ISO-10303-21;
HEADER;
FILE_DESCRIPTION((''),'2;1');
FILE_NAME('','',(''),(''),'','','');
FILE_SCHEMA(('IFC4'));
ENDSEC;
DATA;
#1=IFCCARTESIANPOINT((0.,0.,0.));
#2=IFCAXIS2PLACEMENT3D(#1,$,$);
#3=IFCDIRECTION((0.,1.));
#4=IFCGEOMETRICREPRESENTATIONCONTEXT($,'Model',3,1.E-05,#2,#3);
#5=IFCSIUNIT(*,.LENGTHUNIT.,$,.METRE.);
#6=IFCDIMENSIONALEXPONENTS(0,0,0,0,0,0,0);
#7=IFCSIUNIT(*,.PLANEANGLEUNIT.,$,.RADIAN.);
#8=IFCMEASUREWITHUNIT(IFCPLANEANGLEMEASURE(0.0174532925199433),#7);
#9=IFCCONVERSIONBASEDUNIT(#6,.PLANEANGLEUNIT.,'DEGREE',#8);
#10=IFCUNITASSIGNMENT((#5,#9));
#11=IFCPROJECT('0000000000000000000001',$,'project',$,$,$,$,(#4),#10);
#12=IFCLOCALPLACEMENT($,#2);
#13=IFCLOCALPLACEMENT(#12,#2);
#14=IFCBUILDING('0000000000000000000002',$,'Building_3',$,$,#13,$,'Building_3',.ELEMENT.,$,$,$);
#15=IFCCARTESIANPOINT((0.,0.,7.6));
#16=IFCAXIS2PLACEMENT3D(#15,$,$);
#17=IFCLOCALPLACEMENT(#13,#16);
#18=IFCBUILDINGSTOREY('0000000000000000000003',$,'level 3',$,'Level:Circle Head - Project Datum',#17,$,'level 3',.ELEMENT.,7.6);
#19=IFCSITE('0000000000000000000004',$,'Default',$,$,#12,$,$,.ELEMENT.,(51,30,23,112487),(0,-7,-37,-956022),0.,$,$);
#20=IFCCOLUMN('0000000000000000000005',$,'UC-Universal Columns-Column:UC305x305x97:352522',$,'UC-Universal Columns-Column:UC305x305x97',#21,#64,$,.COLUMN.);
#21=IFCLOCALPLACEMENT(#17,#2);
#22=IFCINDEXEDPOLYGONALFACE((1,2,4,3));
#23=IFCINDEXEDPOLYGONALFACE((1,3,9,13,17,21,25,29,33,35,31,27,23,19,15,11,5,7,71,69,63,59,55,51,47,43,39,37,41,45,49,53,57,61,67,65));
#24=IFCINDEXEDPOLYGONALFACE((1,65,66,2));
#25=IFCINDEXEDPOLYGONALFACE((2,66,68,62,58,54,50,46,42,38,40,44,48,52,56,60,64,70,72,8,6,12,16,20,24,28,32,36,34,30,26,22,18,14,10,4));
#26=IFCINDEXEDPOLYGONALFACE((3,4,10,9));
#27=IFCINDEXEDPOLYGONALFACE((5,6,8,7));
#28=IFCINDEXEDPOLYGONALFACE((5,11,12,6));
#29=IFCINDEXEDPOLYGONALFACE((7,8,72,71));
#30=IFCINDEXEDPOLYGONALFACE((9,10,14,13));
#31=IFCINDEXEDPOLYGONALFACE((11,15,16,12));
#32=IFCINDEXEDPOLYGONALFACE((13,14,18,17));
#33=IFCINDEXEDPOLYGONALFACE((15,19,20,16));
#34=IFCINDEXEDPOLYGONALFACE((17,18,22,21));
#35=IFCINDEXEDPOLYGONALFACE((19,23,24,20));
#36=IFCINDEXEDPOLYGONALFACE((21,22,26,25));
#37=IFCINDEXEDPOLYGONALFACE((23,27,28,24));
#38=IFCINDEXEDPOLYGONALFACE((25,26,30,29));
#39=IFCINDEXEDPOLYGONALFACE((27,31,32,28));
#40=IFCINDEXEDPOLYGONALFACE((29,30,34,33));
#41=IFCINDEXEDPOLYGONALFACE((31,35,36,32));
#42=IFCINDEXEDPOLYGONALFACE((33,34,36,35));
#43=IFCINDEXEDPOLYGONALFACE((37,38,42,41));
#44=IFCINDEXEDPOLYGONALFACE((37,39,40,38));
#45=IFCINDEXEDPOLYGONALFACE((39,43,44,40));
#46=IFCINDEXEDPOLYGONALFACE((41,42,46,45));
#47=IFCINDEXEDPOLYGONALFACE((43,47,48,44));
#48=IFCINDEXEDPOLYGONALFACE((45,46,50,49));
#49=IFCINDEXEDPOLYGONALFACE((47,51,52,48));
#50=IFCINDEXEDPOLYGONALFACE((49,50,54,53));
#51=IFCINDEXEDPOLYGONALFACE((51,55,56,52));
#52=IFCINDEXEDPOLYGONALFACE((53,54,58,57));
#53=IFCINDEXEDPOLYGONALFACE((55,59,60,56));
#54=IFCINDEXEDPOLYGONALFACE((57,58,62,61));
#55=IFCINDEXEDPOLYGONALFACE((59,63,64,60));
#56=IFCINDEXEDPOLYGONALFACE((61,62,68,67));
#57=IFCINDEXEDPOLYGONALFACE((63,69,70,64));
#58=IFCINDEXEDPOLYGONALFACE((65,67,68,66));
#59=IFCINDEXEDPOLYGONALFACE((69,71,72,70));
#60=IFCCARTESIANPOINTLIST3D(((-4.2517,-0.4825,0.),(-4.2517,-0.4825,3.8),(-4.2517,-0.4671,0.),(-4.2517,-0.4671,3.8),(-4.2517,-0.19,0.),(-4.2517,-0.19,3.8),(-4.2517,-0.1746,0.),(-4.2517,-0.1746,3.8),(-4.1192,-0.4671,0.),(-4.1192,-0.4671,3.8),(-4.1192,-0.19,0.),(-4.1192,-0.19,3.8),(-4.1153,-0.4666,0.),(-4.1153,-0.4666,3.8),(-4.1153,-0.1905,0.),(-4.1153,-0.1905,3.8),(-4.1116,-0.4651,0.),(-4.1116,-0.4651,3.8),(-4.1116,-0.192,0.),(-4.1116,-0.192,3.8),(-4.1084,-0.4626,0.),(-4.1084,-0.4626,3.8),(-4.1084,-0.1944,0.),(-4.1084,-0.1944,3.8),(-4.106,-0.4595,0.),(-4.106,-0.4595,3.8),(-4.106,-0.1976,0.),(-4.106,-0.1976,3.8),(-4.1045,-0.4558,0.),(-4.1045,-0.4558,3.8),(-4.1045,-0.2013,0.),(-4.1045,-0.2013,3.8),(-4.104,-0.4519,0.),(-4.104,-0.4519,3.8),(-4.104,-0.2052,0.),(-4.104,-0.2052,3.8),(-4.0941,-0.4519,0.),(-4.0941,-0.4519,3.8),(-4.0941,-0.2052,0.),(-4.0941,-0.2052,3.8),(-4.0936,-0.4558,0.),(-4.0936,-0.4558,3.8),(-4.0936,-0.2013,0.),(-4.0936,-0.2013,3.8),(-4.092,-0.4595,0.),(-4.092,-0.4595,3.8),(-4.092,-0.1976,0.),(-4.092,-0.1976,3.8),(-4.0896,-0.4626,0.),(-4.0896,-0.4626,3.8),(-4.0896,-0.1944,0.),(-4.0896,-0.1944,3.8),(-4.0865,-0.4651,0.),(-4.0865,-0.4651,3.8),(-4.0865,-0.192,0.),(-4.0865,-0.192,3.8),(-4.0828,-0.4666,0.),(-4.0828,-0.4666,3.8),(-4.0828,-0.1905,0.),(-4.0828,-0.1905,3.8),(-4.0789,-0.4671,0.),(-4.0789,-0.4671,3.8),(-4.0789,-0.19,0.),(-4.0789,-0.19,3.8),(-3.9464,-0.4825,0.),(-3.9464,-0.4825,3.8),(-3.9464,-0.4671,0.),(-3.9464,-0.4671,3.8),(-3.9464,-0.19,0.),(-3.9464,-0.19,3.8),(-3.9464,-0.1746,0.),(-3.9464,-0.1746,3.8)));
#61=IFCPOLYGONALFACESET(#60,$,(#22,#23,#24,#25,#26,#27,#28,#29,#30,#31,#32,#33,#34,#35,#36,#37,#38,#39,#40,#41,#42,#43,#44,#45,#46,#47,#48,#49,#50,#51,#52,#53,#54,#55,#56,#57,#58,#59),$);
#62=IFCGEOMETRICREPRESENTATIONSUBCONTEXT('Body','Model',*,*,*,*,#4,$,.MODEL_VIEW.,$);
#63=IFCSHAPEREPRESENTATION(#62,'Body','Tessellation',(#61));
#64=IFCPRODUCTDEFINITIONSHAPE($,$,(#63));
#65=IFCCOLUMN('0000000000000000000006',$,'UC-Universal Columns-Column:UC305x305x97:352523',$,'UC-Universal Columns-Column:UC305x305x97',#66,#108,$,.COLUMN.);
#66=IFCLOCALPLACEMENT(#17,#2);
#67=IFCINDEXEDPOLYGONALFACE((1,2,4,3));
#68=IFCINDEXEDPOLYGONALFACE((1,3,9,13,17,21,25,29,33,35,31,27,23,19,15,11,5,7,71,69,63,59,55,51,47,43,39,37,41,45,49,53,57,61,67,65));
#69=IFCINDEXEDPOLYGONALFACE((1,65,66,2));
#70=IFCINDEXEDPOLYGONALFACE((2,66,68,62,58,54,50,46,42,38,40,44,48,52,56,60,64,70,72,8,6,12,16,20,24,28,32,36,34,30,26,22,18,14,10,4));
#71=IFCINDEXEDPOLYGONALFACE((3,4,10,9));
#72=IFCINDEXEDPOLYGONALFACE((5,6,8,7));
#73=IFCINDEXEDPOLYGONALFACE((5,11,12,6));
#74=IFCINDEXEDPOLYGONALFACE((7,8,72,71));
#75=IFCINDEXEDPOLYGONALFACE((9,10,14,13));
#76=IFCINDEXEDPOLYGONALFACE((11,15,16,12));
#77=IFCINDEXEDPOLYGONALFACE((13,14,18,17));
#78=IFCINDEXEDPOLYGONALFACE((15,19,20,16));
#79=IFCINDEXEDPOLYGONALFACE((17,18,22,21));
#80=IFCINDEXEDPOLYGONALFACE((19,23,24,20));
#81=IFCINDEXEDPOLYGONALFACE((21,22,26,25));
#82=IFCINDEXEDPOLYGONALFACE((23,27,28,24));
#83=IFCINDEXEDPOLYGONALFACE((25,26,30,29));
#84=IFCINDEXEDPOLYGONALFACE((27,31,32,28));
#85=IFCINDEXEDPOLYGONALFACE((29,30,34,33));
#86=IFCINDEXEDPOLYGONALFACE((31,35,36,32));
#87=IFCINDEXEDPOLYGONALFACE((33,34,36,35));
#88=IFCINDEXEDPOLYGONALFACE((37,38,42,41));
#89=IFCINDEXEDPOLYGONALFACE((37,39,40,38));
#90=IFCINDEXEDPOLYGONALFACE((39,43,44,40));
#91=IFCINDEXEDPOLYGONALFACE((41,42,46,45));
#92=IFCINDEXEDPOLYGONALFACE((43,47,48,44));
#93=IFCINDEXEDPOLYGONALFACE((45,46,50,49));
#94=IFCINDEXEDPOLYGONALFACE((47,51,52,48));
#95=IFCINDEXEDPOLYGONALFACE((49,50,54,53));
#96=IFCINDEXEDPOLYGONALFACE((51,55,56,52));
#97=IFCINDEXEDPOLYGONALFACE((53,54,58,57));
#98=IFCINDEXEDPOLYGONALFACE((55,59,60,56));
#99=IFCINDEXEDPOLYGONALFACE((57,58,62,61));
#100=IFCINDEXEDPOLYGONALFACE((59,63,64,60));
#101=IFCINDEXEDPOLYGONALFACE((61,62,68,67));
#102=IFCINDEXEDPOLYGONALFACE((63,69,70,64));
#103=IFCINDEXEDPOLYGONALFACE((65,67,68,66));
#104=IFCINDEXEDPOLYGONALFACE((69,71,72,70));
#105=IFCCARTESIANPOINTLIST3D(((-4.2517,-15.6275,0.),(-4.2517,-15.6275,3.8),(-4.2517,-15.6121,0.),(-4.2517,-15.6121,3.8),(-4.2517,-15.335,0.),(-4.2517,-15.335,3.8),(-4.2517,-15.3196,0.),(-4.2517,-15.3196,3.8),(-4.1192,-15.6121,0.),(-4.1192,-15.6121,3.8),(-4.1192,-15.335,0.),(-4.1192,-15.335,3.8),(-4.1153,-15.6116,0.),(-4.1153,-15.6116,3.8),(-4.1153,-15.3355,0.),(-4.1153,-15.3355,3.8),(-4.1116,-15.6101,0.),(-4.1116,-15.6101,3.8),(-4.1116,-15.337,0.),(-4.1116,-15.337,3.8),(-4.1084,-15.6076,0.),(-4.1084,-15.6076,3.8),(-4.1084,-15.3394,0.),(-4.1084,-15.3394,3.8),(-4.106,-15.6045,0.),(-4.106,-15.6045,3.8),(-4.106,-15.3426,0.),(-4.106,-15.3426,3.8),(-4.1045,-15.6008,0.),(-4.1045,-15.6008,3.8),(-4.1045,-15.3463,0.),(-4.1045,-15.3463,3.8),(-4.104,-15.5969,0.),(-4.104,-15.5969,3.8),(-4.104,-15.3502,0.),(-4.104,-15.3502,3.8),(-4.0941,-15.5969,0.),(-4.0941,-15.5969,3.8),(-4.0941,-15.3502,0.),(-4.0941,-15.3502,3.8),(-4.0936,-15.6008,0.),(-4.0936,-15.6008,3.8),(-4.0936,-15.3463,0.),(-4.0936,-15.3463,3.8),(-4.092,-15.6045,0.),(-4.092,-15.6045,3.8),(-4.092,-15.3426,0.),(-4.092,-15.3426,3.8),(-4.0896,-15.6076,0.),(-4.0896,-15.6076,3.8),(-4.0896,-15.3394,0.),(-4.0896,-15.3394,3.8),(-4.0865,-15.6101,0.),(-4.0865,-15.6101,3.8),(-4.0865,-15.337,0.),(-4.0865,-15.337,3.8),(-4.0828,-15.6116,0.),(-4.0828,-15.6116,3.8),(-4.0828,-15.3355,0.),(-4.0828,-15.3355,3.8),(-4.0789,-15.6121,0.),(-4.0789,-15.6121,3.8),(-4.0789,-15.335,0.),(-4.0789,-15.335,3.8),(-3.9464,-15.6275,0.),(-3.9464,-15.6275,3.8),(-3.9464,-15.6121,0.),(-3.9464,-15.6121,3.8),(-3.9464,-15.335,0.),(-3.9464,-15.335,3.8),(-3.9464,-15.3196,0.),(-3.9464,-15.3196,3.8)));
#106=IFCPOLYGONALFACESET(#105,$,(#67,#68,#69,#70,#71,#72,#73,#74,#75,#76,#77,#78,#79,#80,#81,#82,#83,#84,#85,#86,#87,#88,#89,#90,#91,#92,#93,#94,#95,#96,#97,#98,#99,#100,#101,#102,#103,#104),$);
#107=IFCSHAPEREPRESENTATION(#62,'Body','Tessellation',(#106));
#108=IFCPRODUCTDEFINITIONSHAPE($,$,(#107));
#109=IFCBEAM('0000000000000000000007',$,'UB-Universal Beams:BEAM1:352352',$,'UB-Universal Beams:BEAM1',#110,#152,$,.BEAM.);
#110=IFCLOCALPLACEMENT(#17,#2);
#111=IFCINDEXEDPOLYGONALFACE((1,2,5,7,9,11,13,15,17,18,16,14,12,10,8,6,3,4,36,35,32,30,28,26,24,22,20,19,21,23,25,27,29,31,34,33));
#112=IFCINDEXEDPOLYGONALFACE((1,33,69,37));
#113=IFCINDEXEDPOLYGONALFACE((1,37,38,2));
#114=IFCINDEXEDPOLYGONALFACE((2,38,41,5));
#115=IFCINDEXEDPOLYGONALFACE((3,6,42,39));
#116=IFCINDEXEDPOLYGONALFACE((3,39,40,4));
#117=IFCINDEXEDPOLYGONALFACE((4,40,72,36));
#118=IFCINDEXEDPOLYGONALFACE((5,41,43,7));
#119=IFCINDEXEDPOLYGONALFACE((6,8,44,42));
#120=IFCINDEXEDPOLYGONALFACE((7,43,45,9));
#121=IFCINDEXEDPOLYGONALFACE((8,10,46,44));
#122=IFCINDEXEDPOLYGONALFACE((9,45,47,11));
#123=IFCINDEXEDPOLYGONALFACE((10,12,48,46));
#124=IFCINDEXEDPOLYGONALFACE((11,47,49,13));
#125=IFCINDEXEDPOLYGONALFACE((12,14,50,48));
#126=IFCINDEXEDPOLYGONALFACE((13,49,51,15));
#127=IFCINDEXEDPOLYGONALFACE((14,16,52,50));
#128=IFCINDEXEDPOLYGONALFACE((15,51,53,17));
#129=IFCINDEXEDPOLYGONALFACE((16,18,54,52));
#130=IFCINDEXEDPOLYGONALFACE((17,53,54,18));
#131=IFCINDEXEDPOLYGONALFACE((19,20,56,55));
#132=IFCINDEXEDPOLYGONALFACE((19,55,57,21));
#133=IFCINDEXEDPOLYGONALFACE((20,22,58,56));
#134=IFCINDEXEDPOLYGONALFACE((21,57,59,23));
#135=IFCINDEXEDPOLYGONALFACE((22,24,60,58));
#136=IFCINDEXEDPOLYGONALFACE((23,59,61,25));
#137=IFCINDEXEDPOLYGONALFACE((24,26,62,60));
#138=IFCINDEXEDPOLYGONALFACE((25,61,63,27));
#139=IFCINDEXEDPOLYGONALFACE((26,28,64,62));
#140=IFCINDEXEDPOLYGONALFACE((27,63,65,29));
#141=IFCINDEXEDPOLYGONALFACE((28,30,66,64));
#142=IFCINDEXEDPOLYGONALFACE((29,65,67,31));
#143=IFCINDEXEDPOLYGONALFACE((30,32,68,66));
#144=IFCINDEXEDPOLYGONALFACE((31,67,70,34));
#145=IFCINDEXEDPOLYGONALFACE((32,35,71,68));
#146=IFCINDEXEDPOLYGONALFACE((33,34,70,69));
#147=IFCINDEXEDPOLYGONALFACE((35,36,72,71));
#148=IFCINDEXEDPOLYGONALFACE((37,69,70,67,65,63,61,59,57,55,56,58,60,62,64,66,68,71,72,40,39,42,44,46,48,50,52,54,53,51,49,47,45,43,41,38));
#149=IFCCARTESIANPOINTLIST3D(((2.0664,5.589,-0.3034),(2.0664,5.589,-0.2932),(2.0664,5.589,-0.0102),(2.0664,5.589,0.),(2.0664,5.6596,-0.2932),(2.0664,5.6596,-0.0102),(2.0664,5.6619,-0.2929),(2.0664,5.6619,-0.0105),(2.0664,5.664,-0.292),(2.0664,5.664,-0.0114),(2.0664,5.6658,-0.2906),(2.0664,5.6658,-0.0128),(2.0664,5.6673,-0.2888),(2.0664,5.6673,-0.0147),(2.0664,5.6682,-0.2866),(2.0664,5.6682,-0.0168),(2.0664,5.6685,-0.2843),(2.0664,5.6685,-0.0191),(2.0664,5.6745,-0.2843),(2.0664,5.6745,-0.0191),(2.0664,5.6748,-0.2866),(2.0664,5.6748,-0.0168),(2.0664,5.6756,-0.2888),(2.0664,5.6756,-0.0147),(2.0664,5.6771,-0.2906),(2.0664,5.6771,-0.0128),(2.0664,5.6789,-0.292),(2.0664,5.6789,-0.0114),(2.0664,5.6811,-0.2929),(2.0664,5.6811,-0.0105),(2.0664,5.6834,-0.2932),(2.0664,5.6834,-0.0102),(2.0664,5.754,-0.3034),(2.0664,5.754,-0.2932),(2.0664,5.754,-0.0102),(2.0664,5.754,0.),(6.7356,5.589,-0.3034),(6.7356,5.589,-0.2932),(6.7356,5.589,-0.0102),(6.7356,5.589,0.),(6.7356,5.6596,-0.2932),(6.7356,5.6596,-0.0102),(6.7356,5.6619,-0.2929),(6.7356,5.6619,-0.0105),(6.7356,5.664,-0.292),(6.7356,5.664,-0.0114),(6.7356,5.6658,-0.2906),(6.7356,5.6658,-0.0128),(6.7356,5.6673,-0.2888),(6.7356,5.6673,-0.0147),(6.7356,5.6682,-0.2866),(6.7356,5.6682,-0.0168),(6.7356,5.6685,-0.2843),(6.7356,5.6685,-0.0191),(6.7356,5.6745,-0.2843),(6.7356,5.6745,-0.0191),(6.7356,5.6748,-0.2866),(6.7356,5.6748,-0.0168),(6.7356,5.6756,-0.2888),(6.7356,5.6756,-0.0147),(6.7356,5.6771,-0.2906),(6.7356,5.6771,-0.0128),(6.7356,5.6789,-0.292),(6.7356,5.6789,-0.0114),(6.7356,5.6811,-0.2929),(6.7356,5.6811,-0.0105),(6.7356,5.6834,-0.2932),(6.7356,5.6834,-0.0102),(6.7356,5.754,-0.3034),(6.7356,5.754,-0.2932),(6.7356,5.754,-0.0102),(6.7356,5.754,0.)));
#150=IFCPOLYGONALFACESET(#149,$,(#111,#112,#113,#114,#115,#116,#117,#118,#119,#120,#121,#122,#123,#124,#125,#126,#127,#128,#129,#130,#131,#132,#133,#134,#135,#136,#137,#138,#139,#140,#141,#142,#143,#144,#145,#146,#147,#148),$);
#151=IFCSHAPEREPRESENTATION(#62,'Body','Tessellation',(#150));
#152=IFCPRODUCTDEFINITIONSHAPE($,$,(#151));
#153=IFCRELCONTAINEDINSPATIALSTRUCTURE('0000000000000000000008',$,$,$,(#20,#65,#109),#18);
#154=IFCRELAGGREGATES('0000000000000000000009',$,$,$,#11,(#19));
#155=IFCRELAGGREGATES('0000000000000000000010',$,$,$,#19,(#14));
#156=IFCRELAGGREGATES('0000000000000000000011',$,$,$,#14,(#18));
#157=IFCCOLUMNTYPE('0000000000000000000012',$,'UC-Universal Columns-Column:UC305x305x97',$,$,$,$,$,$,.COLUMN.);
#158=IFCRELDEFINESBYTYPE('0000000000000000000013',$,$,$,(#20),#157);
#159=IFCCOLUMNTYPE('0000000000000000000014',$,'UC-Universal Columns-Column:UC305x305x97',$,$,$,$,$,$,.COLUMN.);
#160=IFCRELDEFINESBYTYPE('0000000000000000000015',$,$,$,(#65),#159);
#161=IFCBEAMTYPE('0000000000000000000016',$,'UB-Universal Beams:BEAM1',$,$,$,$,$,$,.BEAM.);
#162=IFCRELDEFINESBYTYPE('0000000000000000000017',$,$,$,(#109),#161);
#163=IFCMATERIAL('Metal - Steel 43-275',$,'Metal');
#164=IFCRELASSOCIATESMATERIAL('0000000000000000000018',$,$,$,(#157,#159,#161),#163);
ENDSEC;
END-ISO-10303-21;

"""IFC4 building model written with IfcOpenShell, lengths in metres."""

from ifc_helpers import new_model, entity, si_unit, converted_unit, direction, frame, frame_2d, origin, place, context, subcontext, project, spatial, polyline, circle_curve, parameter, trimmed, segment, composite_curve, i_section, outline, extrude, source, transform, mapped, material, material_profile, profile_set, type_object, type_shapes, element, save


model = new_model("IFC4")

# Units and contexts
model_context = context("Model", 3, precision=1e-05, world=origin(), true_north=direction((0.0, 1.0)))
body_context = subcontext(model_context, "Body", "Model", "MODEL_VIEW")
ifc_project = project(units=[si_unit("LENGTHUNIT", "METRE"), converted_unit("PLANEANGLEUNIT", "DEGREE", entity("IfcPlaneAngleMeasure", 0.0174532925199433), si_unit("PLANEANGLEUNIT", "RADIAN"), dimensions=[0, 0, 0, 0, 0, 0, 0])], contexts=[model_context])

# Site, building, storey
site_placement = place(None, origin())
site = spatial("IfcSite", under=ifc_project, at=site_placement, Name="Default", CompositionType="ELEMENT", RefLatitude=(51, 30, 23, 112487), RefLongitude=(0, -7, -37, -956022), RefElevation=0.0)
building_placement = place(site_placement, origin())
building = spatial("IfcBuilding", under=site, at=building_placement, Name="Building_3", LongName="Building_3", CompositionType="ELEMENT")
storey_placement = place(building_placement, frame((0.0, 0.0, 7.6)))
storey = spatial("IfcBuildingStorey", under=building, at=storey_placement, Name="level 3", ObjectType="Level:Circle Head - Project Datum", LongName="level 3", CompositionType="ELEMENT", Elevation=7.6)

# Columns
ifc_material_1 = material(Name="Metal - Steel 43-275", Category="Metal")
ifc_material_profile_1 = material_profile(ifc_material_1, i_section(OverallWidth=0.3053, OverallDepth=0.3079, WebThickness=0.0099, FlangeThickness=0.0154, FilletRadius=0.0152, at=frame_2d((0.0, 0.0), x_axis=(1.0, 0.0))), Name="UC305x305x97")
ifc_profile_set_1 = profile_set([ifc_material_profile_1], Name="UC305x305x97")
column_type_1 = type_object("IfcColumnType", Name="UC-Universal Columns-Column:UC305x305x97", PredefinedType="COLUMN", material=ifc_profile_set_1)
shared_shape_1 = source(origin(), body_context, "Body", "SweptSolid", [
    extrude(i_section(OverallWidth=0.3053, OverallDepth=0.3079, WebThickness=0.0099, FlangeThickness=0.0154, FilletRadius=0.0152, at=frame_2d((0.0, 0.0), x_axis=(1.0, 0.0))), frame((-4.099, -0.3285, 7.6), z_axis=(0.0, 0.0, 1.0), x_axis=(-1.0, 0.0, 0.0)), (0.0, 0.0, 1.0), 3.8),
])
type_shapes(column_type_1, [shared_shape_1])
column_1_placement = place(storey_placement, frame((0.0, 0.0, -7.6)))
element("IfcColumn", 1, at=column_1_placement, inside=storey, type_object=column_type_1, Name="UC-Universal Columns-Column:UC305x305x97:352522", ObjectType="UC-Universal Columns-Column:UC305x305x97", PredefinedType="COLUMN", context=body_context, shape_type="MappedRepresentation", body=[
    mapped(shared_shape_1, transform((0.0, 0.0, 0.0), scale=1.0)),
])
column_type_2 = type_object("IfcColumnType", Name="UC-Universal Columns-Column:UC305x305x97", PredefinedType="COLUMN", material=ifc_profile_set_1)
shared_shape_2 = source(origin(), body_context, "Body", "SweptSolid", [
    extrude(i_section(OverallWidth=0.3053, OverallDepth=0.3079, WebThickness=0.0099, FlangeThickness=0.0154, FilletRadius=0.0152, at=frame_2d((0.0, 0.0), x_axis=(1.0, 0.0))), frame((-4.099, -15.4735, 7.6), z_axis=(0.0, 0.0, 1.0), x_axis=(-1.0, 0.0, 0.0)), (0.0, 0.0, 1.0), 3.8),
])
type_shapes(column_type_2, [shared_shape_2])
column_2_placement = place(storey_placement, frame((0.0, 0.0, -7.6)))
element("IfcColumn", 2, at=column_2_placement, inside=storey, type_object=column_type_2, Name="UC-Universal Columns-Column:UC305x305x97:352523", ObjectType="UC-Universal Columns-Column:UC305x305x97", PredefinedType="COLUMN", context=body_context, shape_type="MappedRepresentation", body=[
    mapped(shared_shape_2, transform((0.0, 0.0, 0.0), scale=1.0)),
])

# Beam
ifc_material_profile_2 = material_profile(ifc_material_1, outline(composite_curve([segment(polyline([(-0.0825, -0.1415), (-0.0825, -0.1517)]), True, "CONTINUOUS"), segment(polyline([(-0.0825, -0.1517), (0.0825, -0.1517)]), True, "CONTINUOUS"), segment(polyline([(0.0825, -0.1517), (0.0825, -0.1415)]), True, "CONTINUOUS"), segment(polyline([(0.0825, -0.1415), (0.0119, -0.1415)]), True, "CONTINUOUS"), segment(trimmed(circle_curve(frame_2d((0.0119, -0.1326), x_axis=(1.0, 0.0)), 0.0089), [parameter(180.0)], [parameter(270.0)], True, "PARAMETER"), False, "CONTINUOUS"), segment(polyline([(0.003, -0.1326), (0.003, 0.1326)]), True, "CONTINUOUS"), segment(trimmed(circle_curve(frame_2d((0.0119, 0.1326), x_axis=(1.0, 0.0)), 0.0089), [parameter(90.0)], [parameter(180.0)], True, "PARAMETER"), False, "CONTINUOUS"), segment(polyline([(0.0119, 0.1415), (0.0825, 0.1415)]), True, "CONTINUOUS"), segment(polyline([(0.0825, 0.1415), (0.0825, 0.1517)]), True, "CONTINUOUS"), segment(polyline([(0.0825, 0.1517), (-0.0825, 0.1517)]), True, "CONTINUOUS"), segment(polyline([(-0.0825, 0.1517), (-0.0825, 0.1415)]), True, "CONTINUOUS"), segment(polyline([(-0.0825, 0.1415), (-0.0119, 0.1415)]), True, "CONTINUOUS"), segment(trimmed(circle_curve(frame_2d((-0.0119, 0.1326), x_axis=(1.0, 0.0)), 0.0089), [parameter(360.0)], [parameter(90.0)], True, "PARAMETER"), False, "CONTINUOUS"), segment(polyline([(-0.003, 0.1326), (-0.003, -0.1326)]), True, "CONTINUOUS"), segment(trimmed(circle_curve(frame_2d((-0.0119, -0.1326), x_axis=(1.0, 0.0)), 0.0089), [parameter(270.0)], [parameter(360.0)], True, "PARAMETER"), False, "CONTINUOUS"), segment(polyline([(-0.0119, -0.1415), (-0.0825, -0.1415)]), True, "CONTINUOUS")], self_intersect=False)), Name="BEAM1")
ifc_profile_set_2 = profile_set([ifc_material_profile_2], Name="BEAM1")
beam_type_1 = type_object("IfcBeamType", Name="UB-Universal Beams:BEAM1", PredefinedType="BEAM", material=ifc_profile_set_2)
shared_shape_3 = source(origin(), body_context, "Body", "SweptSolid", [
    extrude(outline(composite_curve([segment(polyline([(-0.0825, -0.1415), (-0.0825, -0.1517)]), True, "CONTINUOUS"), segment(polyline([(-0.0825, -0.1517), (0.0825, -0.1517)]), True, "CONTINUOUS"), segment(polyline([(0.0825, -0.1517), (0.0825, -0.1415)]), True, "CONTINUOUS"), segment(polyline([(0.0825, -0.1415), (0.0119, -0.1415)]), True, "CONTINUOUS"), segment(trimmed(circle_curve(frame_2d((0.0119, -0.1326), x_axis=(1.0, 0.0)), 0.0089), [parameter(180.0)], [parameter(270.0)], True, "PARAMETER"), False, "CONTINUOUS"), segment(polyline([(0.003, -0.1326), (0.003, 0.1326)]), True, "CONTINUOUS"), segment(trimmed(circle_curve(frame_2d((0.0119, 0.1326), x_axis=(1.0, 0.0)), 0.0089), [parameter(90.0)], [parameter(180.0)], True, "PARAMETER"), False, "CONTINUOUS"), segment(polyline([(0.0119, 0.1415), (0.0825, 0.1415)]), True, "CONTINUOUS"), segment(polyline([(0.0825, 0.1415), (0.0825, 0.1517)]), True, "CONTINUOUS"), segment(polyline([(0.0825, 0.1517), (-0.0825, 0.1517)]), True, "CONTINUOUS"), segment(polyline([(-0.0825, 0.1517), (-0.0825, 0.1415)]), True, "CONTINUOUS"), segment(polyline([(-0.0825, 0.1415), (-0.0119, 0.1415)]), True, "CONTINUOUS"), segment(trimmed(circle_curve(frame_2d((-0.0119, 0.1326), x_axis=(1.0, 0.0)), 0.0089), [parameter(360.0)], [parameter(90.0)], True, "PARAMETER"), False, "CONTINUOUS"), segment(polyline([(-0.003, 0.1326), (-0.003, -0.1326)]), True, "CONTINUOUS"), segment(trimmed(circle_curve(frame_2d((-0.0119, -0.1326), x_axis=(1.0, 0.0)), 0.0089), [parameter(270.0)], [parameter(360.0)], True, "PARAMETER"), False, "CONTINUOUS"), segment(polyline([(-0.0119, -0.1415), (-0.0825, -0.1415)]), True, "CONTINUOUS")], self_intersect=False)), frame((-2.3346, 0.0, 0.0), z_axis=(-1.0, 0.0, 0.0), x_axis=(0.0, -1.0, 0.0)), (0.0, 0.0, -1.0), 4.6692),
])
type_shapes(beam_type_1, [shared_shape_3])
for number, where, name in (
    (3, (4.401, 5.6715, -0.1517), "UB-Universal Beams:BEAM1:352352"),
):
    element("IfcBeam", number, at=place(storey_placement, frame(where)), inside=storey, type_object=beam_type_1, Name=name, ObjectType="UB-Universal Beams:BEAM1", PredefinedType="BEAM", context=body_context, shape_type="MappedRepresentation", body=[
        mapped(shared_shape_3, transform((0.0, 0.0, 0.0), scale=1.0)),
    ])

save(model, "model.ifc")
